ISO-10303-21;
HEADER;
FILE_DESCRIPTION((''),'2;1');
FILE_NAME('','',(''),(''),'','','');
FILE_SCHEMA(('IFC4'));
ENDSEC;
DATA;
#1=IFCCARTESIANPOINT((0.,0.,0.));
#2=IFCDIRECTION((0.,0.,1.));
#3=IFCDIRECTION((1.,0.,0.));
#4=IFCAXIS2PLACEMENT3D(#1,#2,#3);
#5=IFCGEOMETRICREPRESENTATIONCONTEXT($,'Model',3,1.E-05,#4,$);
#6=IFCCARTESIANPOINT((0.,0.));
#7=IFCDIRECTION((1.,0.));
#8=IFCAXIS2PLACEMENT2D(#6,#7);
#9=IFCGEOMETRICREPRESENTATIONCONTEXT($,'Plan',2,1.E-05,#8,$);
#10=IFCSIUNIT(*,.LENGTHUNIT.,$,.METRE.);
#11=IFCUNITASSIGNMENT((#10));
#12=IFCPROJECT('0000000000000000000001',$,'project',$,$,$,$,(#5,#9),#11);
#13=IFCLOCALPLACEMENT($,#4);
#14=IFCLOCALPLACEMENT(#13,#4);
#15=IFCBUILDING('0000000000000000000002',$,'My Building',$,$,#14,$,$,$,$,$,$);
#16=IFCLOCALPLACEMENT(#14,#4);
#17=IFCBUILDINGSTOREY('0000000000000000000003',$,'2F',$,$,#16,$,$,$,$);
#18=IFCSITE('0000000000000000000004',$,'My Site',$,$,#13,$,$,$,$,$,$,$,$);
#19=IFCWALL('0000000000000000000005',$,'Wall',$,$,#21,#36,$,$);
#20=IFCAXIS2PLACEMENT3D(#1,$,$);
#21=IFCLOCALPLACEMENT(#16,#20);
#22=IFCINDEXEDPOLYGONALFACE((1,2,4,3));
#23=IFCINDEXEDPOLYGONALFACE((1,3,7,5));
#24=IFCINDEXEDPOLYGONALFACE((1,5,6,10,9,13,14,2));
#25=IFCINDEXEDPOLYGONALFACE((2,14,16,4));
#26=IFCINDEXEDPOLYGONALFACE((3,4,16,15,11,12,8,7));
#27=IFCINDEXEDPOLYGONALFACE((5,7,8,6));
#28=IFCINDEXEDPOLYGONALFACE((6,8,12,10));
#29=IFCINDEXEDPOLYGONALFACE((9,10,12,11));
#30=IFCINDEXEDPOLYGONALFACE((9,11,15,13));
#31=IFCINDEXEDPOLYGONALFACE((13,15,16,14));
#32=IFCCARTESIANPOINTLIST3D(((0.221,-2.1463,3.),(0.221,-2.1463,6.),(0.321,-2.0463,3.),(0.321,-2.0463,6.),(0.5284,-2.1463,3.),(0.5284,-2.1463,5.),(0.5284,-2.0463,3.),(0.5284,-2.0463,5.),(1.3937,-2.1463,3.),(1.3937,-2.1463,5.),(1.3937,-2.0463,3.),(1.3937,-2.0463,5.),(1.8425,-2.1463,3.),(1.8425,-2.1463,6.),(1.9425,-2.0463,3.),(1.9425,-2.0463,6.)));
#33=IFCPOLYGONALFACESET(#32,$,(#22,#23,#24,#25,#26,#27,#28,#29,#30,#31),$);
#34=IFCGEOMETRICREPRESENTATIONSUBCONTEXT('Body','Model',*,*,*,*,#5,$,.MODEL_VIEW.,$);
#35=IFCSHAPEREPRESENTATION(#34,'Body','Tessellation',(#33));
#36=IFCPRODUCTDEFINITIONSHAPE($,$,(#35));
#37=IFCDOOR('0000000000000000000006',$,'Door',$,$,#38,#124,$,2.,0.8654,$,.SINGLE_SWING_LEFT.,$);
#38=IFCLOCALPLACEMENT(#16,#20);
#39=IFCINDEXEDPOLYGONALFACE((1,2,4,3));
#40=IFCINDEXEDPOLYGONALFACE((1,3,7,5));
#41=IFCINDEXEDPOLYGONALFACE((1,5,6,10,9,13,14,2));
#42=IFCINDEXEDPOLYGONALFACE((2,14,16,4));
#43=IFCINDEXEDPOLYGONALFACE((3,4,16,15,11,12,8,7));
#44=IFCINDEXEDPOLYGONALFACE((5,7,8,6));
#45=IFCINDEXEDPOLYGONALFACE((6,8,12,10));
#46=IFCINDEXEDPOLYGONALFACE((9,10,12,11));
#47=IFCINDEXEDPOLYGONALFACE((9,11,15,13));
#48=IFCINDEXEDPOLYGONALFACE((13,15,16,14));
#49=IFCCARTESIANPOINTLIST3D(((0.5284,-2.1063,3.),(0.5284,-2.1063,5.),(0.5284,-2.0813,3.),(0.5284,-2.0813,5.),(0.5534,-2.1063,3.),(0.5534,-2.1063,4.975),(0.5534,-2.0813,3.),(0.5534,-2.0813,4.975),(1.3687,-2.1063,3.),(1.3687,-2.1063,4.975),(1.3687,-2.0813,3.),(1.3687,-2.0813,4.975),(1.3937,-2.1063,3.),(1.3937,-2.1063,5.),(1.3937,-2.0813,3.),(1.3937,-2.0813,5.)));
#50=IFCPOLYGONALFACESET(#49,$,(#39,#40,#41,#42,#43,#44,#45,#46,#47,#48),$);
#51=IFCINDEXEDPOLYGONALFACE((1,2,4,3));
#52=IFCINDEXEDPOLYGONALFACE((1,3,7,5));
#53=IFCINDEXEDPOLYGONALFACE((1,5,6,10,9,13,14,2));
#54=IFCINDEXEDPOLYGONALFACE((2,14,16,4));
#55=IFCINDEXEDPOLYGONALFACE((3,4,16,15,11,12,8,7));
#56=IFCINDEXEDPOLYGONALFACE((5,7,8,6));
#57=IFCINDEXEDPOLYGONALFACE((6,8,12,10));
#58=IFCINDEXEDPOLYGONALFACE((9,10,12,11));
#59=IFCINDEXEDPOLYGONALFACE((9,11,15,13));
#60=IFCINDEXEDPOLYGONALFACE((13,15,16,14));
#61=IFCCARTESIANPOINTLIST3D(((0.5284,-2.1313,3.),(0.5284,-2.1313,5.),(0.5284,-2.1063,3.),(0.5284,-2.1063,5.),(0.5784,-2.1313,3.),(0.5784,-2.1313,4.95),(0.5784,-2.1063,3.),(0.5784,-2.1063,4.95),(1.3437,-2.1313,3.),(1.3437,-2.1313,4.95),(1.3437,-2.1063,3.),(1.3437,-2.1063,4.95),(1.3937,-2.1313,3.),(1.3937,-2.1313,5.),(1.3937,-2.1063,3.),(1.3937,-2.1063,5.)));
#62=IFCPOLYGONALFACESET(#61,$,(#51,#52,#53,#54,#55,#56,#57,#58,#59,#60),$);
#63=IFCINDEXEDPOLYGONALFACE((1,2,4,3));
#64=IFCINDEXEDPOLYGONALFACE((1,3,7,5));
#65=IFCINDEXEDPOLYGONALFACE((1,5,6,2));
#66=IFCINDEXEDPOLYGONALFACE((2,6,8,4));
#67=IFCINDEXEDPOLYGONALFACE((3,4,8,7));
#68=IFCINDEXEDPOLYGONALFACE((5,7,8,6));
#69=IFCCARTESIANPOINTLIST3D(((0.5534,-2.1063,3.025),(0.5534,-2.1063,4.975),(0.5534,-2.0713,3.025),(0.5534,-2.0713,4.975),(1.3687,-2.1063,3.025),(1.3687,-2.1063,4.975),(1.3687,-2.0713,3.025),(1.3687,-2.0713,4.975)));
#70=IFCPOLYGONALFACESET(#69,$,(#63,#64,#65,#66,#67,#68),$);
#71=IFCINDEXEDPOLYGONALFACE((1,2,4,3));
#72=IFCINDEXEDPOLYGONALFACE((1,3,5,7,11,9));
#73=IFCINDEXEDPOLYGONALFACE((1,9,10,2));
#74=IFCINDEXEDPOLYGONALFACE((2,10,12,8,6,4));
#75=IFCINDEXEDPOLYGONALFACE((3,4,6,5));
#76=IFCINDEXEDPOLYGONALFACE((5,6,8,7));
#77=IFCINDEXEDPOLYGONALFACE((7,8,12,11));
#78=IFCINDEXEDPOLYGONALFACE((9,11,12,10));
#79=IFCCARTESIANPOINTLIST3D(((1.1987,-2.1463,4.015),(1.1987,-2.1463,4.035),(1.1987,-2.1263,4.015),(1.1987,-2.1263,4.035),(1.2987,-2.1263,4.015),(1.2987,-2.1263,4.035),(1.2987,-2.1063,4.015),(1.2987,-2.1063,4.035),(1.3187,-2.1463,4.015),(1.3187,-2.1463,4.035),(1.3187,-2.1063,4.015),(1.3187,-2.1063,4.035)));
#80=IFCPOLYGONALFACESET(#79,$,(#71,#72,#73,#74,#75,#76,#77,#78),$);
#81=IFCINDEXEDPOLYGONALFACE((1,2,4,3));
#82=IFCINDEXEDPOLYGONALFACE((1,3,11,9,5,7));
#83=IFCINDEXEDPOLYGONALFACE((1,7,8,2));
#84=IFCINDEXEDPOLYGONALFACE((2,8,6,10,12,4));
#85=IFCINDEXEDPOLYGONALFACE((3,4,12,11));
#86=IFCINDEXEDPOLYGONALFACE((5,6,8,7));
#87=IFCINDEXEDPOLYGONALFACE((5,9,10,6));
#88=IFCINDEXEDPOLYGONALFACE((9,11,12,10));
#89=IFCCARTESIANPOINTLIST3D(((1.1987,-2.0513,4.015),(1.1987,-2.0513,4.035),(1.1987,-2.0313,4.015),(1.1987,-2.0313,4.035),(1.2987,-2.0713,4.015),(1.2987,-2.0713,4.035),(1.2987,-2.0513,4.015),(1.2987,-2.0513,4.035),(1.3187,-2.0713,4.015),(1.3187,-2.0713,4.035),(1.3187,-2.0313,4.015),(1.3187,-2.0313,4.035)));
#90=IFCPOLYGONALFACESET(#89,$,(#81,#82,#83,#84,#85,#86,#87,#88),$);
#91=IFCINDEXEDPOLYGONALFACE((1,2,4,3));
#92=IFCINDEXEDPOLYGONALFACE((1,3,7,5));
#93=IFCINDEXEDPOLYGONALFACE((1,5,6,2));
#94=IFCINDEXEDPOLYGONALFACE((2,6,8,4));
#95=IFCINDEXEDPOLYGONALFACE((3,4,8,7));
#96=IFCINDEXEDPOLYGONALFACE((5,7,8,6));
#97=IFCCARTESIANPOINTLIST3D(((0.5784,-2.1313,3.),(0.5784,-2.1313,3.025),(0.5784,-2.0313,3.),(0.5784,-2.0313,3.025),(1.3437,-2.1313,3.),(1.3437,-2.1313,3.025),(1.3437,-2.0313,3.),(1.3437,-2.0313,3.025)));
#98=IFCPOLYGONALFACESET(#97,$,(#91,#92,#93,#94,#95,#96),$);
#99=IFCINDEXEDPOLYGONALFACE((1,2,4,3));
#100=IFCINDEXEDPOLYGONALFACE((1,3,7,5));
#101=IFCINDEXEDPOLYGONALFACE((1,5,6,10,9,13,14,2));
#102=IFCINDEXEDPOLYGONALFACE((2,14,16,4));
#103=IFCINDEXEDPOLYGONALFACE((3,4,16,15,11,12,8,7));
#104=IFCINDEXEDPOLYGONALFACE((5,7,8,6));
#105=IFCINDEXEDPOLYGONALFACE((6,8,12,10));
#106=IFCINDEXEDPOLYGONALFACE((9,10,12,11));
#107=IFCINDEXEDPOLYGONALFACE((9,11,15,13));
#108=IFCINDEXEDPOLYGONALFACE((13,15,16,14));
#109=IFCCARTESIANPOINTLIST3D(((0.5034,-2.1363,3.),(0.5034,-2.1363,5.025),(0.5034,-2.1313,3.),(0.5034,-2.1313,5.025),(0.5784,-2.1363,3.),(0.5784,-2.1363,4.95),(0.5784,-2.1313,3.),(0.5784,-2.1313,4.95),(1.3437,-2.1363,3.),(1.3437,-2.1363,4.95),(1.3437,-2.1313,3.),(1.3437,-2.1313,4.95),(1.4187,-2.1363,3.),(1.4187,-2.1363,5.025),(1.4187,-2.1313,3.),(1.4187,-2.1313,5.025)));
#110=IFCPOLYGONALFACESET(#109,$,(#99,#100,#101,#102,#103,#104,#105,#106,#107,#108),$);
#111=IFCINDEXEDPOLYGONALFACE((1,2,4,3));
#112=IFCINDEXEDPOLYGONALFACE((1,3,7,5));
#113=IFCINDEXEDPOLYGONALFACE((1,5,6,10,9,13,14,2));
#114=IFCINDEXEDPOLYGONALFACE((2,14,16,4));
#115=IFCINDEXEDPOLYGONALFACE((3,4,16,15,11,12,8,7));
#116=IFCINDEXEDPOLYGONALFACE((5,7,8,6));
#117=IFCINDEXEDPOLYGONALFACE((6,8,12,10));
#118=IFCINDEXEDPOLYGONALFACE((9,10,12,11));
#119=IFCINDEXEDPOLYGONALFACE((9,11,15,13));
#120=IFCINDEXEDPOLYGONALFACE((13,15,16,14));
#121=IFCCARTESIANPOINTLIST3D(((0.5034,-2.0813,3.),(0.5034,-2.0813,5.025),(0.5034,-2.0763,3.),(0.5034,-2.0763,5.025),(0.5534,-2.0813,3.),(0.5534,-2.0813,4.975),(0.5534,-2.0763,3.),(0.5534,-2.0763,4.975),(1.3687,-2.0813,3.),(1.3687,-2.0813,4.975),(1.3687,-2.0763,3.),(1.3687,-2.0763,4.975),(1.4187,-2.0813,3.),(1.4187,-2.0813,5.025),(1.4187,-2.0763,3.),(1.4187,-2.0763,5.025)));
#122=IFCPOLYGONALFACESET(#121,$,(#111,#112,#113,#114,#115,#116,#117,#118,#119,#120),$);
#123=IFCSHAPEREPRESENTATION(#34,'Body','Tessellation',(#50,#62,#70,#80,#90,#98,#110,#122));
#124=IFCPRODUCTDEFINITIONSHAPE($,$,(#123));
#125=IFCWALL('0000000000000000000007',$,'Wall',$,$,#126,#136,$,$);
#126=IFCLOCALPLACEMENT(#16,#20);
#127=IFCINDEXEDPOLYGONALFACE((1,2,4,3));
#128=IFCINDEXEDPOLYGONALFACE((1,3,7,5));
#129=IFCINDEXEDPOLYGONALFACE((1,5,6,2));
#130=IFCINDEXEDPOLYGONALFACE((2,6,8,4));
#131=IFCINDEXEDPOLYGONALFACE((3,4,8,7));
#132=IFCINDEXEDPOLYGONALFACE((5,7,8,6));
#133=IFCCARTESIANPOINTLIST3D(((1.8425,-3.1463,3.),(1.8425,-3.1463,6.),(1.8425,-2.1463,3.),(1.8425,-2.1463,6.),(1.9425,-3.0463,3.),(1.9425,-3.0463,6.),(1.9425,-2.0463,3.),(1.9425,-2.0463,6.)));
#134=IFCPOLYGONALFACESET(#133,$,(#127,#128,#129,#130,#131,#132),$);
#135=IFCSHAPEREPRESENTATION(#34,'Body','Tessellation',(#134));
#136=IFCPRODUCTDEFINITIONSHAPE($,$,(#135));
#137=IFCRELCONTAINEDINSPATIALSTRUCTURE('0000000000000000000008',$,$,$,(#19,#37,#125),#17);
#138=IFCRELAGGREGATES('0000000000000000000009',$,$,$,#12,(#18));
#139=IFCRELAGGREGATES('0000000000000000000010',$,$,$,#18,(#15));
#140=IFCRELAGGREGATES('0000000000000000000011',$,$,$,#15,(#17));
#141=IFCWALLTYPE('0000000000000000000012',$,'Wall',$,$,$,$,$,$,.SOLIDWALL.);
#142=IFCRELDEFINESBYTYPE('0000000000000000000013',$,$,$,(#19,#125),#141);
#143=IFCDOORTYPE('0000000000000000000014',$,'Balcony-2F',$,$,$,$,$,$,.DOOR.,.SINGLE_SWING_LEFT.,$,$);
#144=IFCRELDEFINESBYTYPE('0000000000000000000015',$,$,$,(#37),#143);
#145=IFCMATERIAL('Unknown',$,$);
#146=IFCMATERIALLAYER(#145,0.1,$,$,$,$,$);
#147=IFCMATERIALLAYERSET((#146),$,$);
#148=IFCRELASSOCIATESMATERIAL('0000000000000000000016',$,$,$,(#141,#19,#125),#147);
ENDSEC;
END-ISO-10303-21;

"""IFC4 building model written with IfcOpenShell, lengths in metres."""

from ifc_helpers import new_model, entity, si_unit, frame, origin_with_axes, origin_2d_with_axis, place, context, subcontext, project, spatial, line, indexed_curve, outline, extrude, shape, source, transform, mapped, material, layer, layer_set, layer_usage, type_object, type_shapes, element, fill, save


model = new_model("IFC4")

# Units and contexts
model_context = context("Model", 3, precision=1e-05, world=origin_with_axes())
plan_context = context("Plan", 2, precision=1e-05, world=origin_2d_with_axis())
body_context_1 = subcontext(model_context, "Body", "Model", "MODEL_VIEW")
body_context_2 = subcontext(plan_context, "Body", "Plan", "PLAN_VIEW")
ifc_project = project(units=[si_unit("LENGTHUNIT", "METRE")], contexts=[model_context, plan_context])

# Site, building, storey
site_placement = place(None, origin_with_axes())
site = spatial("IfcSite", under=ifc_project, at=site_placement, Name="My Site")
building_placement = place(site_placement, origin_with_axes())
building = spatial("IfcBuilding", under=site, at=building_placement, Name="My Building")
storey_placement = place(building_placement, origin_with_axes())
storey = spatial("IfcBuildingStorey", under=building, at=storey_placement, Name="2F")

# Shared definitions
ifc_material_1 = material(Name="Unknown")

# Shared definitions
ifc_layer_1 = layer(ifc_material_1, 0.1)
ifc_layer_set_1 = layer_set([ifc_layer_1])
wall_type = type_object("IfcWallType", Name="Wall", PredefinedType="SOLIDWALL", material=ifc_layer_set_1)

# Wall, opening, door
ifc_layer_usage_1 = layer_usage(ifc_layer_set_1, "AXIS2", "POSITIVE", 0.0)
wall_1_placement = place(storey_placement, frame((0.221, -2.1463, 3.0), z_axis=(0.0, 0.0, 1.0), x_axis=(1.0, 0.0, 0.0)))
wall_1 = element("IfcWall", 1, at=wall_1_placement, inside=storey, type_object=wall_type, material=ifc_layer_usage_1, Name="Wall", context=body_context_1, shape_type="SweptSolid", body=[
    extrude(outline(indexed_curve([(0.0, 0.0), (0.1, 0.1), (1.7215, 0.1), (1.6215, 0.0)], segments=[line(1, 2, 3, 4, 1)])), origin_with_axes(), (0.0, 0.0, 1.0), 3.0),
])
shared_shape_1 = source(origin_with_axes(), body_context_1, "Body", "SweptSolid", [
    extrude(outline(indexed_curve([(0.0, 0.0), (0.8654, 0.0), (0.8654, 2.0), (0.0, 2.0)], segments=[line(1, 2, 3, 4, 1)])), frame((0.0, -0.6, 0.0), z_axis=(0.0, -1.0, 0.0), x_axis=(1.0, 0.0, 0.0)), (0.0, 0.0, -1.0), 1.2),
])
opening_1_placement = place(wall_1_placement, frame((0.3074, 0.015, 0.0), z_axis=(0.0, 0.0, 1.0), x_axis=(1.0, 0.0, 0.0)))
opening_1 = element("IfcOpeningElement", 2, at=opening_1_placement, cuts=wall_1, PredefinedType="OPENING", context=body_context_1, shape_type="MappedRepresentation", body=[
    mapped(shared_shape_1, transform((0.0, 0.0, 0.0), x_axis=(1.0, 0.0, 0.0), y_axis=(0.0, 1.0, 0.0), z_axis=(0.0, 0.0, 1.0), scale=1.0)),
])
door_type_1 = type_object("IfcDoorType", Name="Balcony-2F", OperationType="SINGLE_SWING_LEFT", PredefinedType="DOOR")
shared_shape_2 = source(origin_with_axes(), body_context_1, "Body", "SweptSolid", [
    extrude(outline(indexed_curve([(0.0, 0.0), (0.0, 2.0), (0.8654, 2.0), (0.8654, 0.0), (0.8404, 0.0), (0.8404, 1.975), (0.025, 1.975), (0.025, 0.0)], segments=[line(1, 2, 3, 4, 5, 6, 7, 8, 1)])), frame((0.0, 0.025, 0.0), z_axis=(0.0, -1.0, 0.0), x_axis=(1.0, 0.0, 0.0)), (0.0, 0.0, -1.0), 0.025),
    extrude(outline(indexed_curve([(0.0, 0.0), (0.0, 2.0), (0.8654, 2.0), (0.8654, 0.0), (0.8154, 0.0), (0.8154, 1.95), (0.05, 1.95), (0.05, 0.0)], segments=[line(1, 2, 3, 4, 5, 6, 7, 8, 1)])), frame((0.0, 0.0, 0.0), z_axis=(0.0, -1.0, 0.0), x_axis=(1.0, 0.0, 0.0)), (0.0, 0.0, -1.0), 0.025),
    extrude(outline(indexed_curve([(0.0, 0.0), (0.8154, 0.0), (0.8154, 0.035), (0.0, 0.035)], segments=[line(1, 2, 3, 4, 1)])), frame((0.025, 0.025, 0.025), z_axis=(0.0, 0.0, 1.0), x_axis=(1.0, 0.0, 0.0)), (0.0, 0.0, 1.0), 1.95),
    extrude(outline(indexed_curve([(0.0, 0.0), (0.0, -0.04), (-0.12, -0.04), (-0.12, -0.02), (-0.02, -0.02), (-0.02, 0.0)], segments=[line(1, 2, 3, 4, 5, 6, 1)])), frame((0.7904, 0.025, 1.015), z_axis=(0.0, 0.0, 1.0), x_axis=(1.0, 0.0, 0.0)), (0.0, 0.0, 1.0), 0.02),
    extrude(outline(indexed_curve([(0.0, 0.0), (0.0, 0.04), (-0.12, 0.04), (-0.12, 0.02), (-0.02, 0.02), (-0.02, 0.0)], segments=[line(1, 2, 3, 4, 5, 6, 1)])), frame((0.7904, 0.06, 1.015), z_axis=(0.0, 0.0, 1.0), x_axis=(1.0, 0.0, 0.0)), (0.0, 0.0, 1.0), 0.02),
    extrude(outline(indexed_curve([(0.0, 0.0), (0.7654, 0.0), (0.7654, 0.1), (0.0, 0.1)], segments=[line(1, 2, 3, 4, 1)])), frame((0.05, 0.0, 0.0), z_axis=(0.0, 0.0, 1.0), x_axis=(1.0, 0.0, 0.0)), (0.0, 0.0, 1.0), 0.025),
    extrude(outline(indexed_curve([(0.0, 0.0), (0.0, 2.025), (0.9154, 2.025), (0.9154, 0.0), (0.8404, 0.0), (0.8404, 1.95), (0.075, 1.95), (0.075, 0.0)], segments=[line(1, 2, 3, 4, 5, 6, 7, 8, 1)])), frame((-0.025, -0.005, 0.0), z_axis=(0.0, -1.0, 0.0), x_axis=(1.0, 0.0, 0.0)), (0.0, 0.0, -1.0), 0.005),
    extrude(outline(indexed_curve([(0.0, 0.0), (0.0, 2.025), (0.9154, 2.025), (0.9154, 0.0), (0.8654, 0.0), (0.8654, 1.975), (0.05, 1.975), (0.05, 0.0)], segments=[line(1, 2, 3, 4, 5, 6, 7, 8, 1)])), frame((-0.025, 0.05, 0.0), z_axis=(0.0, -1.0, 0.0), x_axis=(1.0, 0.0, 0.0)), (0.0, 0.0, -1.0), 0.005),
])
shared_shape_3 = source(origin_with_axes(), body_context_2, "Body", "Curve2D", [
    entity("IfcIndexedPolyCurve", entity("IfcCartesianPointList2D", [[0.0, 0.0], [0.0, 0.05], [0.025, 0.05], [0.025, 0.025], [0.05, 0.025], [0.05, 0.0]]), [entity("IfcLineIndex", [1, 2, 3, 4, 5, 6, 1])]),
    entity("IfcIndexedPolyCurve", entity("IfcCartesianPointList2D", [[0.8654, 0.0], [0.8654, 0.05], [0.8404, 0.05], [0.8404, 0.025], [0.8154, 0.025], [0.8154, 0.0]]), [entity("IfcLineIndex", [1, 2, 3, 4, 5, 6, 1])]),
    entity("IfcTrimmedCurve", entity("IfcEllipse", entity("IfcAxis2Placement2D", entity("IfcCartesianPoint", [0.06, 0.05]), entity("IfcDirection", [1.0, 0.0])), 0.7804, 0.8154), [entity("IfcCartesianPoint", [0.8404, 0.05])], [entity("IfcCartesianPoint", [0.06, 0.8654])], True, "CARTESIAN"),
    entity("IfcIndexedPolyCurve", entity("IfcCartesianPointList2D", [[0.025, 0.05], [0.06, 0.05], [0.06, 0.8654], [0.025, 0.8654]]), [entity("IfcLineIndex", [1, 2, 3, 4, 1])]),
])
type_shapes(door_type_1, [shared_shape_2, shared_shape_3])
door_1_placement = place(opening_1_placement, frame((0.0, 0.0, 0.0), z_axis=(0.0, 0.0, 1.0), x_axis=(1.0, 0.0, 0.0)))
door_1 = element("IfcDoor", 3, at=door_1_placement, inside=storey, type_object=door_type_1, Name="Door", OperationType="SINGLE_SWING_LEFT", OverallHeight=2.0, OverallWidth=0.8654, shapes=[
    shape(body_context_1, "Body", "MappedRepresentation", [mapped(shared_shape_2, transform((0.0, 0.0, 0.0), x_axis=(1.0, 0.0, 0.0), y_axis=(0.0, 1.0, 0.0), z_axis=(0.0, 0.0, 1.0), scale=1.0))]),
    shape(body_context_2, "Body", "MappedRepresentation", [mapped(shared_shape_3, transform((0.0, 0.0, 0.0), x_axis=(1.0, 0.0, 0.0), y_axis=(0.0, 1.0, 0.0), z_axis=(0.0, 0.0, 1.0), scale=1.0))]),
])
fill(opening_1, door_1)

# Wall
ifc_layer_usage_2 = layer_usage(ifc_layer_set_1, "AXIS2", "POSITIVE", 0.0)
wall_2_placement = place(storey_placement, frame((1.8425, -2.1463, 3.0), z_axis=(0.0, 0.0, 1.0), x_axis=(0.0, -1.0, 0.0)))
element("IfcWall", 4, at=wall_2_placement, inside=storey, type_object=wall_type, material=ifc_layer_usage_2, Name="Wall", context=body_context_1, shape_type="SweptSolid", body=[
    extrude(outline(indexed_curve([(0.0, 0.0), (-0.1, 0.1), (0.9, 0.1), (1.0, 0.0)], segments=[line(1, 2, 3, 4, 1)])), origin_with_axes(), (0.0, 0.0, 1.0), 3.0),
])

save(model, "model.ifc")
